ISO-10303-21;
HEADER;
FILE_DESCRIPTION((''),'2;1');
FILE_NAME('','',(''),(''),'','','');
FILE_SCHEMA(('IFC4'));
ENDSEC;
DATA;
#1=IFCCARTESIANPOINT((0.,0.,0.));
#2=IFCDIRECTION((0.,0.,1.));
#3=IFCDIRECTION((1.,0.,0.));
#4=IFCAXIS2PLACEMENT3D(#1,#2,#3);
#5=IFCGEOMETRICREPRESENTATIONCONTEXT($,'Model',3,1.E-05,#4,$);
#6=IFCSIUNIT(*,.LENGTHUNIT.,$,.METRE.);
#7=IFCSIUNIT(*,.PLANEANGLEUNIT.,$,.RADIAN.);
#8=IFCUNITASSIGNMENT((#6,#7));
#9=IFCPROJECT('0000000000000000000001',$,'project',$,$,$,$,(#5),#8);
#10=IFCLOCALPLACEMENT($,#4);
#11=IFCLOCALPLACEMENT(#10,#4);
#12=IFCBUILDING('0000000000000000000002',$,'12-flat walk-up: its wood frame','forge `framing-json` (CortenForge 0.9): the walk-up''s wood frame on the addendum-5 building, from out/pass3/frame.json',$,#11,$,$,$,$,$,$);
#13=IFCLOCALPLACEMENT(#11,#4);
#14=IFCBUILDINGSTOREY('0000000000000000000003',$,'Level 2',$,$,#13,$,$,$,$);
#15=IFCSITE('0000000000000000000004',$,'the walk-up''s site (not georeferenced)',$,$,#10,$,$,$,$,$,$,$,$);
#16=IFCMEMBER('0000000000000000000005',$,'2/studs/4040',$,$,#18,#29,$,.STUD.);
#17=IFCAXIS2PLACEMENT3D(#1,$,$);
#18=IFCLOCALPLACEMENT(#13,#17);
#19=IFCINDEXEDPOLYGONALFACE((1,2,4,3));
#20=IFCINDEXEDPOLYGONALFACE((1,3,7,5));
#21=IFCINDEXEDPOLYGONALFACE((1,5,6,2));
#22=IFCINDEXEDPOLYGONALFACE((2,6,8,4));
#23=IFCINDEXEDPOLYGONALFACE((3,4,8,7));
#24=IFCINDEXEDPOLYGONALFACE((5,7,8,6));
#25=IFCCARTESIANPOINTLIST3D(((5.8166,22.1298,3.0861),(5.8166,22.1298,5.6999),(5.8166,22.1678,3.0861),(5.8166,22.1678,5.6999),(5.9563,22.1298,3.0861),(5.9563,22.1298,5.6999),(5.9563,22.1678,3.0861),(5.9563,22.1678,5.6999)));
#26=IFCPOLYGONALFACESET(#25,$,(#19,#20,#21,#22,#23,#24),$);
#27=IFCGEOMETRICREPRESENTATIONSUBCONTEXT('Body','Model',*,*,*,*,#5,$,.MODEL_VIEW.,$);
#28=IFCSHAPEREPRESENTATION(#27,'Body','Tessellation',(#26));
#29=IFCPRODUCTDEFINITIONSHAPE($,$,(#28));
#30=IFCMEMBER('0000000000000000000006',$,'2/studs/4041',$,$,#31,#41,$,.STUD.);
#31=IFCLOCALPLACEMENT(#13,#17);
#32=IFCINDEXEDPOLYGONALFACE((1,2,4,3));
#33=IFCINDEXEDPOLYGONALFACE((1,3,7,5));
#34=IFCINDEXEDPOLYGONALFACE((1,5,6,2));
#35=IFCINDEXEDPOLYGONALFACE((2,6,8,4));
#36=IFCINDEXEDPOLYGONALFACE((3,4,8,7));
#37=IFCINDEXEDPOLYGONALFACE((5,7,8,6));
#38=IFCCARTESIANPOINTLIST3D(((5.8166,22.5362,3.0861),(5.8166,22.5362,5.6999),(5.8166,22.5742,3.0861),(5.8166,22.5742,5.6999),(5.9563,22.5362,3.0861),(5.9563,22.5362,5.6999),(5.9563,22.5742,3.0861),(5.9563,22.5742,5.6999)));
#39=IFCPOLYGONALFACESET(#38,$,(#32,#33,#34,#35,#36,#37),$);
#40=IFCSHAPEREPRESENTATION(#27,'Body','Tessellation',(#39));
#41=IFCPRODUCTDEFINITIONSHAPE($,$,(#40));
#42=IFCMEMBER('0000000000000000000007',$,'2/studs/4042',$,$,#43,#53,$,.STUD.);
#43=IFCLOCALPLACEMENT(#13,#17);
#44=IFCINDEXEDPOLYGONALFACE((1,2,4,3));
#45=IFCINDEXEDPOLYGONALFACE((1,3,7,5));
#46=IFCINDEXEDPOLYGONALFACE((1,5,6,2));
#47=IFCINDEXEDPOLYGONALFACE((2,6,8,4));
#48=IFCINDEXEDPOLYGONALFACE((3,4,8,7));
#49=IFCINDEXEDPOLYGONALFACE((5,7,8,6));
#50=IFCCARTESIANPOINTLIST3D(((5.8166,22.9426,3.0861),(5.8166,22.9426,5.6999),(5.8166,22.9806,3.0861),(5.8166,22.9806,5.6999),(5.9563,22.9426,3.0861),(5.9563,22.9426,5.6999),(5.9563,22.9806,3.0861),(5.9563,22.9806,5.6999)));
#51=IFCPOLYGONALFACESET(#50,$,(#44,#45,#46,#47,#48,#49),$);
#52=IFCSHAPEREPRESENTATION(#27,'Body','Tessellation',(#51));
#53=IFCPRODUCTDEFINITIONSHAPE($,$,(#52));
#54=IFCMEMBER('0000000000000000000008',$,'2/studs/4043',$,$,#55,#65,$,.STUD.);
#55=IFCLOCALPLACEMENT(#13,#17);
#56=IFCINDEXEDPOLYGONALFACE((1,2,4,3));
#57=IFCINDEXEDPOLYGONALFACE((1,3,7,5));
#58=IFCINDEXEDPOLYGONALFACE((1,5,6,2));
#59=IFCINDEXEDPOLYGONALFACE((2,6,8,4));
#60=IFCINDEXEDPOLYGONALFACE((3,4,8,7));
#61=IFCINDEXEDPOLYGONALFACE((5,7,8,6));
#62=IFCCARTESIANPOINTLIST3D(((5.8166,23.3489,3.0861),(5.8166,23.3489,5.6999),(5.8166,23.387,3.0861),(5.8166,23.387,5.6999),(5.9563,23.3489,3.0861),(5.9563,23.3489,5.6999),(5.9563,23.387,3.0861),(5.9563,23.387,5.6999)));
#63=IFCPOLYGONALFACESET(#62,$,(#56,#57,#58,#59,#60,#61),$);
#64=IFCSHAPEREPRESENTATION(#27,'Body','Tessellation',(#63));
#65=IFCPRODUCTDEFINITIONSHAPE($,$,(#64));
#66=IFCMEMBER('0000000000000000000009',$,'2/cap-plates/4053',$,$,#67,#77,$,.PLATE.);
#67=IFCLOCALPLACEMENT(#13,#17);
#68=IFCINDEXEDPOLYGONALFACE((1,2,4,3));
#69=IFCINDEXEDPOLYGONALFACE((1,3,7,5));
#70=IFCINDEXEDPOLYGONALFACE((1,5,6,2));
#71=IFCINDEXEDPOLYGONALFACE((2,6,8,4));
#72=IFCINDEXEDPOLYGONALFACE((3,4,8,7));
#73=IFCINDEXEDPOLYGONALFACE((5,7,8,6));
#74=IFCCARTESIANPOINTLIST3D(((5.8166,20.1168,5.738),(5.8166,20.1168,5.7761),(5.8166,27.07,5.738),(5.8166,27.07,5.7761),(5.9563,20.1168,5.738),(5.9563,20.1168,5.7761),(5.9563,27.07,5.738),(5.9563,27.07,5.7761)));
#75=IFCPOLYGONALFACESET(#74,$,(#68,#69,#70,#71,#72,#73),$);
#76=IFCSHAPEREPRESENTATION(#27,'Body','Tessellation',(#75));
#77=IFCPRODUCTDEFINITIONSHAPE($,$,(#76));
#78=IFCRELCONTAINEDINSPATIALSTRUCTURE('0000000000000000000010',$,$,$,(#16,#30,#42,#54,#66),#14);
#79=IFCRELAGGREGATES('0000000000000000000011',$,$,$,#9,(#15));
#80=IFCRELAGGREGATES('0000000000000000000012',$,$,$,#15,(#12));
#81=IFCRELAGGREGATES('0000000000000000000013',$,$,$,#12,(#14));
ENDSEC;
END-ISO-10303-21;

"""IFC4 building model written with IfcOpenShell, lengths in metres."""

from ifc_helpers import new_model, si_unit, frame, frame_2d, origin, origin_with_axes, place, context, subcontext, project, spatial, rectangle, extrude, element, save


model = new_model("IFC4")

# Units and contexts
model_context = context("Model", 3, precision=1e-05, world=origin_with_axes())
body_context = subcontext(model_context, "Body", "Model", "MODEL_VIEW")
ifc_project = project(units=[si_unit("LENGTHUNIT", "METRE"), si_unit("PLANEANGLEUNIT", "RADIAN")], contexts=[model_context])

# Site, building, storey
site_placement = place(None, origin_with_axes())
site = spatial("IfcSite", under=ifc_project, at=site_placement, Name="the walk-up's site (not georeferenced)")
building_placement = place(site_placement, origin_with_axes())
building = spatial("IfcBuilding", under=site, at=building_placement, Name="12-flat walk-up: its wood frame", Description="forge `framing-json` (CortenForge 0.9): the walk-up's wood frame on the addendum-5 building, from out/pass3/frame.json")
storey_placement = place(building_placement, origin_with_axes())
storey = spatial("IfcBuildingStorey", under=building, at=storey_placement, Name="Level 2")

# Members
for number, where, z_axis, x_axis, name in (
    (1, (5.8166, 22.1298, 3.0861), (0.0, 0.0, 1.0), (1.0, 0.0, 0.0), "2/studs/4040"),
    (2, (5.8166, 22.5361, 3.0861), (0.0, 0.0, 1.0), (1.0, 0.0, 0.0), "2/studs/4041"),
    (3, (5.8166, 22.9426, 3.0861), (0.0, 0.0, 1.0), (1.0, 0.0, 0.0), "2/studs/4042"),
    (4, (5.8166, 23.3489, 3.0861), (0.0, 0.0, 1.0), (1.0, 0.0, 0.0), "2/studs/4043"),
):
    element("IfcMember", number, at=place(storey_placement, frame(where, z_axis=z_axis, x_axis=x_axis)), inside=storey, Name=name, PredefinedType="STUD", context=body_context, shape_type="SweptSolid", body=[
        extrude(rectangle(XDim=0.1397, YDim=0.0381, at=frame_2d((0.0698, 0.0191))), origin(), (0.0, 0.0, 1.0), 2.6138),
    ])
member_placement = place(storey_placement, frame((5.8166, 20.1168, 5.738), z_axis=(0.0, 0.0, 1.0), x_axis=(1.0, 0.0, 0.0)))
element("IfcMember", 5, at=member_placement, inside=storey, Name="2/cap-plates/4053", PredefinedType="PLATE", context=body_context, shape_type="SweptSolid", body=[
    extrude(rectangle(XDim=0.1397, YDim=6.9532, at=frame_2d((0.0698, 3.4766))), origin(), (0.0, 0.0, 1.0), 0.0381),
])

save(model, "model.ifc")
